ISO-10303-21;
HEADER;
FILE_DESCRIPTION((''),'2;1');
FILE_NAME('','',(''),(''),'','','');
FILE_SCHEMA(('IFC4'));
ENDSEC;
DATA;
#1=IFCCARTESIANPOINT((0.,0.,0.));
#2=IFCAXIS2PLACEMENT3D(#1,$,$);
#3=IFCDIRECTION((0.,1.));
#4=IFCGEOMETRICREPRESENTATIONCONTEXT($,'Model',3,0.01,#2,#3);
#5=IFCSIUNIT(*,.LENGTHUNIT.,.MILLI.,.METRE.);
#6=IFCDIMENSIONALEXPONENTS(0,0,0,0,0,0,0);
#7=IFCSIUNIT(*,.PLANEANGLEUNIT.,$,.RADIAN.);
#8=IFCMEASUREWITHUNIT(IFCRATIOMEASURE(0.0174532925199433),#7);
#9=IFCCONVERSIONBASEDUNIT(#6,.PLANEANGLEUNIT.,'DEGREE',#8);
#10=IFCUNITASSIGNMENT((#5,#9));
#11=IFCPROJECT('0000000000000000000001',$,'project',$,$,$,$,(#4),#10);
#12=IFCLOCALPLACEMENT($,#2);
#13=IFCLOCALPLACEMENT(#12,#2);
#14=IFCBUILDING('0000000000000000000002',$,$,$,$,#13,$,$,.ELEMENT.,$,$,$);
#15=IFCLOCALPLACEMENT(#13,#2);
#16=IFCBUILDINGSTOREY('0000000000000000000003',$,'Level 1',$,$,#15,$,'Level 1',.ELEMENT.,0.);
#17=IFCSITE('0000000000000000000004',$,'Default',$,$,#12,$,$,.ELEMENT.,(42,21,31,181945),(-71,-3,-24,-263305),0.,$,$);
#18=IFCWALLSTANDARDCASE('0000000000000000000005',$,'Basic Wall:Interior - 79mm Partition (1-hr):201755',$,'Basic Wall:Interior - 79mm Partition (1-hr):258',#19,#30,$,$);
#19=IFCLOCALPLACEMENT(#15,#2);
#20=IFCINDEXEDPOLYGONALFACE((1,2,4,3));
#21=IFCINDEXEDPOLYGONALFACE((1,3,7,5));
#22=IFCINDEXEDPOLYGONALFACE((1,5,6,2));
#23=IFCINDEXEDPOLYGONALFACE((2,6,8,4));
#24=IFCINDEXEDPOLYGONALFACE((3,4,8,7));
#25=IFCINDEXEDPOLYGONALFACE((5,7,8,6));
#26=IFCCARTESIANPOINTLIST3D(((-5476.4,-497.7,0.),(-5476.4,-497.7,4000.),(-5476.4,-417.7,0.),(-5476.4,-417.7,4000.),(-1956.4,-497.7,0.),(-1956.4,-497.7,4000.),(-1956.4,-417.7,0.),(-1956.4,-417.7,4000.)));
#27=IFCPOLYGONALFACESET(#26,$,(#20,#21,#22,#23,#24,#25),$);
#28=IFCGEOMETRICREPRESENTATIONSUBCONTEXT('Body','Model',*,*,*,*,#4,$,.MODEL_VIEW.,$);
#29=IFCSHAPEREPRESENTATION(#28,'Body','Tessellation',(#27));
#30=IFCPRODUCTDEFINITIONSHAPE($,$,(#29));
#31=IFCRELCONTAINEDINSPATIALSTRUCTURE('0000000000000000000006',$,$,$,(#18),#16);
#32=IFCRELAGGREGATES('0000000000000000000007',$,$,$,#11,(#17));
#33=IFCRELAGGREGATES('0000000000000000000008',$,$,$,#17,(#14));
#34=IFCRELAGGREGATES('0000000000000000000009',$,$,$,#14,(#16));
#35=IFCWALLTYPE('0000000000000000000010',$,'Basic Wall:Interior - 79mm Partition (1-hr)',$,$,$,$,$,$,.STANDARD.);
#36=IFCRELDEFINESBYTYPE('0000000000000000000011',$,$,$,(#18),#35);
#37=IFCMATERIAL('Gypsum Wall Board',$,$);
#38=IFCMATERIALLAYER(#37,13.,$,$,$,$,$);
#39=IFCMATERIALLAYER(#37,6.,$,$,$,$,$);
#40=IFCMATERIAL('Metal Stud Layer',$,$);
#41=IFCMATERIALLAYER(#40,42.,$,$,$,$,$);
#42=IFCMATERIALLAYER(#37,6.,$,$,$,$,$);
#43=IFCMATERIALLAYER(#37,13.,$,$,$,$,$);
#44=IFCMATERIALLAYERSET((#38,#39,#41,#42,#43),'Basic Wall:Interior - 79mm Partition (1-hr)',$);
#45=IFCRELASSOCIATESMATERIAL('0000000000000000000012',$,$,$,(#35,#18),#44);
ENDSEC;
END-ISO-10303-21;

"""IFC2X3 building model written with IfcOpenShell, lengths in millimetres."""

from ifc_helpers import new_model, entity, si_unit, converted_unit, direction, frame, frame_2d, origin, place, context, subcontext, project, spatial, rectangle, extrude, material, layer, layer_set, layer_usage, type_object, element, save


model = new_model("IFC2X3")

# Units and contexts
model_context = context("Model", 3, precision=0.01, world=origin(), true_north=direction((0.0, 1.0)))
body_context = subcontext(model_context, "Body", "Model", "MODEL_VIEW")
ifc_project = project(units=[si_unit("LENGTHUNIT", "METRE", prefix="MILLI"), converted_unit("PLANEANGLEUNIT", "DEGREE", entity("IfcRatioMeasure", 0.0174532925199433), si_unit("PLANEANGLEUNIT", "RADIAN"), dimensions=[0, 0, 0, 0, 0, 0, 0])], contexts=[model_context])

# Site, building, storey
site_placement = place(None, origin())
site = spatial("IfcSite", under=ifc_project, at=site_placement, Name="Default", CompositionType="ELEMENT", RefLatitude=(42, 21, 31, 181945), RefLongitude=(-71, -3, -24, -263305), RefElevation=0.0)
building_placement = place(site_placement, origin())
building = spatial("IfcBuilding", under=site, at=building_placement, CompositionType="ELEMENT")
storey_placement = place(building_placement, origin())
storey = spatial("IfcBuildingStorey", under=building, at=storey_placement, Name="Level 1", LongName="Level 1", CompositionType="ELEMENT", Elevation=0.0)

# Wall
ifc_material_1 = material(Name="Gypsum Wall Board")
ifc_layer_1 = layer(ifc_material_1, 13.0)
ifc_layer_2 = layer(ifc_material_1, 6.0)
ifc_material_2 = material(Name="Metal Stud Layer")
ifc_layer_3 = layer(ifc_material_2, 42.0)
ifc_layer_4 = layer(ifc_material_1, 6.0)
ifc_layer_5 = layer(ifc_material_1, 13.0)
ifc_layer_set_1 = layer_set([ifc_layer_1, ifc_layer_2, ifc_layer_3, ifc_layer_4, ifc_layer_5], Name="Basic Wall:Interior - 79mm Partition (1-hr)")
wall_type_1 = type_object("IfcWallType", Name="Basic Wall:Interior - 79mm Partition (1-hr)", PredefinedType="STANDARD", material=ifc_layer_set_1)
ifc_layer_usage_1 = layer_usage(ifc_layer_set_1, "AXIS2", "NEGATIVE", 40.0)
wall_1_placement = place(storey_placement, frame((-5476.4, -457.7, 0.0)))
element("IfcWallStandardCase", 1, at=wall_1_placement, inside=storey, type_object=wall_type_1, material=ifc_layer_usage_1, Name="Basic Wall:Interior - 79mm Partition (1-hr):201755", ObjectType="Basic Wall:Interior - 79mm Partition (1-hr):258", context=body_context, shape_type="SweptSolid", body=[
    extrude(rectangle(XDim=3520.0, YDim=80.0, at=frame_2d((1760.0, 0.0), x_axis=(-1.0, 0.0))), origin(), (0.0, 0.0, 1.0), 4000.0),
])

save(model, "model.ifc")
